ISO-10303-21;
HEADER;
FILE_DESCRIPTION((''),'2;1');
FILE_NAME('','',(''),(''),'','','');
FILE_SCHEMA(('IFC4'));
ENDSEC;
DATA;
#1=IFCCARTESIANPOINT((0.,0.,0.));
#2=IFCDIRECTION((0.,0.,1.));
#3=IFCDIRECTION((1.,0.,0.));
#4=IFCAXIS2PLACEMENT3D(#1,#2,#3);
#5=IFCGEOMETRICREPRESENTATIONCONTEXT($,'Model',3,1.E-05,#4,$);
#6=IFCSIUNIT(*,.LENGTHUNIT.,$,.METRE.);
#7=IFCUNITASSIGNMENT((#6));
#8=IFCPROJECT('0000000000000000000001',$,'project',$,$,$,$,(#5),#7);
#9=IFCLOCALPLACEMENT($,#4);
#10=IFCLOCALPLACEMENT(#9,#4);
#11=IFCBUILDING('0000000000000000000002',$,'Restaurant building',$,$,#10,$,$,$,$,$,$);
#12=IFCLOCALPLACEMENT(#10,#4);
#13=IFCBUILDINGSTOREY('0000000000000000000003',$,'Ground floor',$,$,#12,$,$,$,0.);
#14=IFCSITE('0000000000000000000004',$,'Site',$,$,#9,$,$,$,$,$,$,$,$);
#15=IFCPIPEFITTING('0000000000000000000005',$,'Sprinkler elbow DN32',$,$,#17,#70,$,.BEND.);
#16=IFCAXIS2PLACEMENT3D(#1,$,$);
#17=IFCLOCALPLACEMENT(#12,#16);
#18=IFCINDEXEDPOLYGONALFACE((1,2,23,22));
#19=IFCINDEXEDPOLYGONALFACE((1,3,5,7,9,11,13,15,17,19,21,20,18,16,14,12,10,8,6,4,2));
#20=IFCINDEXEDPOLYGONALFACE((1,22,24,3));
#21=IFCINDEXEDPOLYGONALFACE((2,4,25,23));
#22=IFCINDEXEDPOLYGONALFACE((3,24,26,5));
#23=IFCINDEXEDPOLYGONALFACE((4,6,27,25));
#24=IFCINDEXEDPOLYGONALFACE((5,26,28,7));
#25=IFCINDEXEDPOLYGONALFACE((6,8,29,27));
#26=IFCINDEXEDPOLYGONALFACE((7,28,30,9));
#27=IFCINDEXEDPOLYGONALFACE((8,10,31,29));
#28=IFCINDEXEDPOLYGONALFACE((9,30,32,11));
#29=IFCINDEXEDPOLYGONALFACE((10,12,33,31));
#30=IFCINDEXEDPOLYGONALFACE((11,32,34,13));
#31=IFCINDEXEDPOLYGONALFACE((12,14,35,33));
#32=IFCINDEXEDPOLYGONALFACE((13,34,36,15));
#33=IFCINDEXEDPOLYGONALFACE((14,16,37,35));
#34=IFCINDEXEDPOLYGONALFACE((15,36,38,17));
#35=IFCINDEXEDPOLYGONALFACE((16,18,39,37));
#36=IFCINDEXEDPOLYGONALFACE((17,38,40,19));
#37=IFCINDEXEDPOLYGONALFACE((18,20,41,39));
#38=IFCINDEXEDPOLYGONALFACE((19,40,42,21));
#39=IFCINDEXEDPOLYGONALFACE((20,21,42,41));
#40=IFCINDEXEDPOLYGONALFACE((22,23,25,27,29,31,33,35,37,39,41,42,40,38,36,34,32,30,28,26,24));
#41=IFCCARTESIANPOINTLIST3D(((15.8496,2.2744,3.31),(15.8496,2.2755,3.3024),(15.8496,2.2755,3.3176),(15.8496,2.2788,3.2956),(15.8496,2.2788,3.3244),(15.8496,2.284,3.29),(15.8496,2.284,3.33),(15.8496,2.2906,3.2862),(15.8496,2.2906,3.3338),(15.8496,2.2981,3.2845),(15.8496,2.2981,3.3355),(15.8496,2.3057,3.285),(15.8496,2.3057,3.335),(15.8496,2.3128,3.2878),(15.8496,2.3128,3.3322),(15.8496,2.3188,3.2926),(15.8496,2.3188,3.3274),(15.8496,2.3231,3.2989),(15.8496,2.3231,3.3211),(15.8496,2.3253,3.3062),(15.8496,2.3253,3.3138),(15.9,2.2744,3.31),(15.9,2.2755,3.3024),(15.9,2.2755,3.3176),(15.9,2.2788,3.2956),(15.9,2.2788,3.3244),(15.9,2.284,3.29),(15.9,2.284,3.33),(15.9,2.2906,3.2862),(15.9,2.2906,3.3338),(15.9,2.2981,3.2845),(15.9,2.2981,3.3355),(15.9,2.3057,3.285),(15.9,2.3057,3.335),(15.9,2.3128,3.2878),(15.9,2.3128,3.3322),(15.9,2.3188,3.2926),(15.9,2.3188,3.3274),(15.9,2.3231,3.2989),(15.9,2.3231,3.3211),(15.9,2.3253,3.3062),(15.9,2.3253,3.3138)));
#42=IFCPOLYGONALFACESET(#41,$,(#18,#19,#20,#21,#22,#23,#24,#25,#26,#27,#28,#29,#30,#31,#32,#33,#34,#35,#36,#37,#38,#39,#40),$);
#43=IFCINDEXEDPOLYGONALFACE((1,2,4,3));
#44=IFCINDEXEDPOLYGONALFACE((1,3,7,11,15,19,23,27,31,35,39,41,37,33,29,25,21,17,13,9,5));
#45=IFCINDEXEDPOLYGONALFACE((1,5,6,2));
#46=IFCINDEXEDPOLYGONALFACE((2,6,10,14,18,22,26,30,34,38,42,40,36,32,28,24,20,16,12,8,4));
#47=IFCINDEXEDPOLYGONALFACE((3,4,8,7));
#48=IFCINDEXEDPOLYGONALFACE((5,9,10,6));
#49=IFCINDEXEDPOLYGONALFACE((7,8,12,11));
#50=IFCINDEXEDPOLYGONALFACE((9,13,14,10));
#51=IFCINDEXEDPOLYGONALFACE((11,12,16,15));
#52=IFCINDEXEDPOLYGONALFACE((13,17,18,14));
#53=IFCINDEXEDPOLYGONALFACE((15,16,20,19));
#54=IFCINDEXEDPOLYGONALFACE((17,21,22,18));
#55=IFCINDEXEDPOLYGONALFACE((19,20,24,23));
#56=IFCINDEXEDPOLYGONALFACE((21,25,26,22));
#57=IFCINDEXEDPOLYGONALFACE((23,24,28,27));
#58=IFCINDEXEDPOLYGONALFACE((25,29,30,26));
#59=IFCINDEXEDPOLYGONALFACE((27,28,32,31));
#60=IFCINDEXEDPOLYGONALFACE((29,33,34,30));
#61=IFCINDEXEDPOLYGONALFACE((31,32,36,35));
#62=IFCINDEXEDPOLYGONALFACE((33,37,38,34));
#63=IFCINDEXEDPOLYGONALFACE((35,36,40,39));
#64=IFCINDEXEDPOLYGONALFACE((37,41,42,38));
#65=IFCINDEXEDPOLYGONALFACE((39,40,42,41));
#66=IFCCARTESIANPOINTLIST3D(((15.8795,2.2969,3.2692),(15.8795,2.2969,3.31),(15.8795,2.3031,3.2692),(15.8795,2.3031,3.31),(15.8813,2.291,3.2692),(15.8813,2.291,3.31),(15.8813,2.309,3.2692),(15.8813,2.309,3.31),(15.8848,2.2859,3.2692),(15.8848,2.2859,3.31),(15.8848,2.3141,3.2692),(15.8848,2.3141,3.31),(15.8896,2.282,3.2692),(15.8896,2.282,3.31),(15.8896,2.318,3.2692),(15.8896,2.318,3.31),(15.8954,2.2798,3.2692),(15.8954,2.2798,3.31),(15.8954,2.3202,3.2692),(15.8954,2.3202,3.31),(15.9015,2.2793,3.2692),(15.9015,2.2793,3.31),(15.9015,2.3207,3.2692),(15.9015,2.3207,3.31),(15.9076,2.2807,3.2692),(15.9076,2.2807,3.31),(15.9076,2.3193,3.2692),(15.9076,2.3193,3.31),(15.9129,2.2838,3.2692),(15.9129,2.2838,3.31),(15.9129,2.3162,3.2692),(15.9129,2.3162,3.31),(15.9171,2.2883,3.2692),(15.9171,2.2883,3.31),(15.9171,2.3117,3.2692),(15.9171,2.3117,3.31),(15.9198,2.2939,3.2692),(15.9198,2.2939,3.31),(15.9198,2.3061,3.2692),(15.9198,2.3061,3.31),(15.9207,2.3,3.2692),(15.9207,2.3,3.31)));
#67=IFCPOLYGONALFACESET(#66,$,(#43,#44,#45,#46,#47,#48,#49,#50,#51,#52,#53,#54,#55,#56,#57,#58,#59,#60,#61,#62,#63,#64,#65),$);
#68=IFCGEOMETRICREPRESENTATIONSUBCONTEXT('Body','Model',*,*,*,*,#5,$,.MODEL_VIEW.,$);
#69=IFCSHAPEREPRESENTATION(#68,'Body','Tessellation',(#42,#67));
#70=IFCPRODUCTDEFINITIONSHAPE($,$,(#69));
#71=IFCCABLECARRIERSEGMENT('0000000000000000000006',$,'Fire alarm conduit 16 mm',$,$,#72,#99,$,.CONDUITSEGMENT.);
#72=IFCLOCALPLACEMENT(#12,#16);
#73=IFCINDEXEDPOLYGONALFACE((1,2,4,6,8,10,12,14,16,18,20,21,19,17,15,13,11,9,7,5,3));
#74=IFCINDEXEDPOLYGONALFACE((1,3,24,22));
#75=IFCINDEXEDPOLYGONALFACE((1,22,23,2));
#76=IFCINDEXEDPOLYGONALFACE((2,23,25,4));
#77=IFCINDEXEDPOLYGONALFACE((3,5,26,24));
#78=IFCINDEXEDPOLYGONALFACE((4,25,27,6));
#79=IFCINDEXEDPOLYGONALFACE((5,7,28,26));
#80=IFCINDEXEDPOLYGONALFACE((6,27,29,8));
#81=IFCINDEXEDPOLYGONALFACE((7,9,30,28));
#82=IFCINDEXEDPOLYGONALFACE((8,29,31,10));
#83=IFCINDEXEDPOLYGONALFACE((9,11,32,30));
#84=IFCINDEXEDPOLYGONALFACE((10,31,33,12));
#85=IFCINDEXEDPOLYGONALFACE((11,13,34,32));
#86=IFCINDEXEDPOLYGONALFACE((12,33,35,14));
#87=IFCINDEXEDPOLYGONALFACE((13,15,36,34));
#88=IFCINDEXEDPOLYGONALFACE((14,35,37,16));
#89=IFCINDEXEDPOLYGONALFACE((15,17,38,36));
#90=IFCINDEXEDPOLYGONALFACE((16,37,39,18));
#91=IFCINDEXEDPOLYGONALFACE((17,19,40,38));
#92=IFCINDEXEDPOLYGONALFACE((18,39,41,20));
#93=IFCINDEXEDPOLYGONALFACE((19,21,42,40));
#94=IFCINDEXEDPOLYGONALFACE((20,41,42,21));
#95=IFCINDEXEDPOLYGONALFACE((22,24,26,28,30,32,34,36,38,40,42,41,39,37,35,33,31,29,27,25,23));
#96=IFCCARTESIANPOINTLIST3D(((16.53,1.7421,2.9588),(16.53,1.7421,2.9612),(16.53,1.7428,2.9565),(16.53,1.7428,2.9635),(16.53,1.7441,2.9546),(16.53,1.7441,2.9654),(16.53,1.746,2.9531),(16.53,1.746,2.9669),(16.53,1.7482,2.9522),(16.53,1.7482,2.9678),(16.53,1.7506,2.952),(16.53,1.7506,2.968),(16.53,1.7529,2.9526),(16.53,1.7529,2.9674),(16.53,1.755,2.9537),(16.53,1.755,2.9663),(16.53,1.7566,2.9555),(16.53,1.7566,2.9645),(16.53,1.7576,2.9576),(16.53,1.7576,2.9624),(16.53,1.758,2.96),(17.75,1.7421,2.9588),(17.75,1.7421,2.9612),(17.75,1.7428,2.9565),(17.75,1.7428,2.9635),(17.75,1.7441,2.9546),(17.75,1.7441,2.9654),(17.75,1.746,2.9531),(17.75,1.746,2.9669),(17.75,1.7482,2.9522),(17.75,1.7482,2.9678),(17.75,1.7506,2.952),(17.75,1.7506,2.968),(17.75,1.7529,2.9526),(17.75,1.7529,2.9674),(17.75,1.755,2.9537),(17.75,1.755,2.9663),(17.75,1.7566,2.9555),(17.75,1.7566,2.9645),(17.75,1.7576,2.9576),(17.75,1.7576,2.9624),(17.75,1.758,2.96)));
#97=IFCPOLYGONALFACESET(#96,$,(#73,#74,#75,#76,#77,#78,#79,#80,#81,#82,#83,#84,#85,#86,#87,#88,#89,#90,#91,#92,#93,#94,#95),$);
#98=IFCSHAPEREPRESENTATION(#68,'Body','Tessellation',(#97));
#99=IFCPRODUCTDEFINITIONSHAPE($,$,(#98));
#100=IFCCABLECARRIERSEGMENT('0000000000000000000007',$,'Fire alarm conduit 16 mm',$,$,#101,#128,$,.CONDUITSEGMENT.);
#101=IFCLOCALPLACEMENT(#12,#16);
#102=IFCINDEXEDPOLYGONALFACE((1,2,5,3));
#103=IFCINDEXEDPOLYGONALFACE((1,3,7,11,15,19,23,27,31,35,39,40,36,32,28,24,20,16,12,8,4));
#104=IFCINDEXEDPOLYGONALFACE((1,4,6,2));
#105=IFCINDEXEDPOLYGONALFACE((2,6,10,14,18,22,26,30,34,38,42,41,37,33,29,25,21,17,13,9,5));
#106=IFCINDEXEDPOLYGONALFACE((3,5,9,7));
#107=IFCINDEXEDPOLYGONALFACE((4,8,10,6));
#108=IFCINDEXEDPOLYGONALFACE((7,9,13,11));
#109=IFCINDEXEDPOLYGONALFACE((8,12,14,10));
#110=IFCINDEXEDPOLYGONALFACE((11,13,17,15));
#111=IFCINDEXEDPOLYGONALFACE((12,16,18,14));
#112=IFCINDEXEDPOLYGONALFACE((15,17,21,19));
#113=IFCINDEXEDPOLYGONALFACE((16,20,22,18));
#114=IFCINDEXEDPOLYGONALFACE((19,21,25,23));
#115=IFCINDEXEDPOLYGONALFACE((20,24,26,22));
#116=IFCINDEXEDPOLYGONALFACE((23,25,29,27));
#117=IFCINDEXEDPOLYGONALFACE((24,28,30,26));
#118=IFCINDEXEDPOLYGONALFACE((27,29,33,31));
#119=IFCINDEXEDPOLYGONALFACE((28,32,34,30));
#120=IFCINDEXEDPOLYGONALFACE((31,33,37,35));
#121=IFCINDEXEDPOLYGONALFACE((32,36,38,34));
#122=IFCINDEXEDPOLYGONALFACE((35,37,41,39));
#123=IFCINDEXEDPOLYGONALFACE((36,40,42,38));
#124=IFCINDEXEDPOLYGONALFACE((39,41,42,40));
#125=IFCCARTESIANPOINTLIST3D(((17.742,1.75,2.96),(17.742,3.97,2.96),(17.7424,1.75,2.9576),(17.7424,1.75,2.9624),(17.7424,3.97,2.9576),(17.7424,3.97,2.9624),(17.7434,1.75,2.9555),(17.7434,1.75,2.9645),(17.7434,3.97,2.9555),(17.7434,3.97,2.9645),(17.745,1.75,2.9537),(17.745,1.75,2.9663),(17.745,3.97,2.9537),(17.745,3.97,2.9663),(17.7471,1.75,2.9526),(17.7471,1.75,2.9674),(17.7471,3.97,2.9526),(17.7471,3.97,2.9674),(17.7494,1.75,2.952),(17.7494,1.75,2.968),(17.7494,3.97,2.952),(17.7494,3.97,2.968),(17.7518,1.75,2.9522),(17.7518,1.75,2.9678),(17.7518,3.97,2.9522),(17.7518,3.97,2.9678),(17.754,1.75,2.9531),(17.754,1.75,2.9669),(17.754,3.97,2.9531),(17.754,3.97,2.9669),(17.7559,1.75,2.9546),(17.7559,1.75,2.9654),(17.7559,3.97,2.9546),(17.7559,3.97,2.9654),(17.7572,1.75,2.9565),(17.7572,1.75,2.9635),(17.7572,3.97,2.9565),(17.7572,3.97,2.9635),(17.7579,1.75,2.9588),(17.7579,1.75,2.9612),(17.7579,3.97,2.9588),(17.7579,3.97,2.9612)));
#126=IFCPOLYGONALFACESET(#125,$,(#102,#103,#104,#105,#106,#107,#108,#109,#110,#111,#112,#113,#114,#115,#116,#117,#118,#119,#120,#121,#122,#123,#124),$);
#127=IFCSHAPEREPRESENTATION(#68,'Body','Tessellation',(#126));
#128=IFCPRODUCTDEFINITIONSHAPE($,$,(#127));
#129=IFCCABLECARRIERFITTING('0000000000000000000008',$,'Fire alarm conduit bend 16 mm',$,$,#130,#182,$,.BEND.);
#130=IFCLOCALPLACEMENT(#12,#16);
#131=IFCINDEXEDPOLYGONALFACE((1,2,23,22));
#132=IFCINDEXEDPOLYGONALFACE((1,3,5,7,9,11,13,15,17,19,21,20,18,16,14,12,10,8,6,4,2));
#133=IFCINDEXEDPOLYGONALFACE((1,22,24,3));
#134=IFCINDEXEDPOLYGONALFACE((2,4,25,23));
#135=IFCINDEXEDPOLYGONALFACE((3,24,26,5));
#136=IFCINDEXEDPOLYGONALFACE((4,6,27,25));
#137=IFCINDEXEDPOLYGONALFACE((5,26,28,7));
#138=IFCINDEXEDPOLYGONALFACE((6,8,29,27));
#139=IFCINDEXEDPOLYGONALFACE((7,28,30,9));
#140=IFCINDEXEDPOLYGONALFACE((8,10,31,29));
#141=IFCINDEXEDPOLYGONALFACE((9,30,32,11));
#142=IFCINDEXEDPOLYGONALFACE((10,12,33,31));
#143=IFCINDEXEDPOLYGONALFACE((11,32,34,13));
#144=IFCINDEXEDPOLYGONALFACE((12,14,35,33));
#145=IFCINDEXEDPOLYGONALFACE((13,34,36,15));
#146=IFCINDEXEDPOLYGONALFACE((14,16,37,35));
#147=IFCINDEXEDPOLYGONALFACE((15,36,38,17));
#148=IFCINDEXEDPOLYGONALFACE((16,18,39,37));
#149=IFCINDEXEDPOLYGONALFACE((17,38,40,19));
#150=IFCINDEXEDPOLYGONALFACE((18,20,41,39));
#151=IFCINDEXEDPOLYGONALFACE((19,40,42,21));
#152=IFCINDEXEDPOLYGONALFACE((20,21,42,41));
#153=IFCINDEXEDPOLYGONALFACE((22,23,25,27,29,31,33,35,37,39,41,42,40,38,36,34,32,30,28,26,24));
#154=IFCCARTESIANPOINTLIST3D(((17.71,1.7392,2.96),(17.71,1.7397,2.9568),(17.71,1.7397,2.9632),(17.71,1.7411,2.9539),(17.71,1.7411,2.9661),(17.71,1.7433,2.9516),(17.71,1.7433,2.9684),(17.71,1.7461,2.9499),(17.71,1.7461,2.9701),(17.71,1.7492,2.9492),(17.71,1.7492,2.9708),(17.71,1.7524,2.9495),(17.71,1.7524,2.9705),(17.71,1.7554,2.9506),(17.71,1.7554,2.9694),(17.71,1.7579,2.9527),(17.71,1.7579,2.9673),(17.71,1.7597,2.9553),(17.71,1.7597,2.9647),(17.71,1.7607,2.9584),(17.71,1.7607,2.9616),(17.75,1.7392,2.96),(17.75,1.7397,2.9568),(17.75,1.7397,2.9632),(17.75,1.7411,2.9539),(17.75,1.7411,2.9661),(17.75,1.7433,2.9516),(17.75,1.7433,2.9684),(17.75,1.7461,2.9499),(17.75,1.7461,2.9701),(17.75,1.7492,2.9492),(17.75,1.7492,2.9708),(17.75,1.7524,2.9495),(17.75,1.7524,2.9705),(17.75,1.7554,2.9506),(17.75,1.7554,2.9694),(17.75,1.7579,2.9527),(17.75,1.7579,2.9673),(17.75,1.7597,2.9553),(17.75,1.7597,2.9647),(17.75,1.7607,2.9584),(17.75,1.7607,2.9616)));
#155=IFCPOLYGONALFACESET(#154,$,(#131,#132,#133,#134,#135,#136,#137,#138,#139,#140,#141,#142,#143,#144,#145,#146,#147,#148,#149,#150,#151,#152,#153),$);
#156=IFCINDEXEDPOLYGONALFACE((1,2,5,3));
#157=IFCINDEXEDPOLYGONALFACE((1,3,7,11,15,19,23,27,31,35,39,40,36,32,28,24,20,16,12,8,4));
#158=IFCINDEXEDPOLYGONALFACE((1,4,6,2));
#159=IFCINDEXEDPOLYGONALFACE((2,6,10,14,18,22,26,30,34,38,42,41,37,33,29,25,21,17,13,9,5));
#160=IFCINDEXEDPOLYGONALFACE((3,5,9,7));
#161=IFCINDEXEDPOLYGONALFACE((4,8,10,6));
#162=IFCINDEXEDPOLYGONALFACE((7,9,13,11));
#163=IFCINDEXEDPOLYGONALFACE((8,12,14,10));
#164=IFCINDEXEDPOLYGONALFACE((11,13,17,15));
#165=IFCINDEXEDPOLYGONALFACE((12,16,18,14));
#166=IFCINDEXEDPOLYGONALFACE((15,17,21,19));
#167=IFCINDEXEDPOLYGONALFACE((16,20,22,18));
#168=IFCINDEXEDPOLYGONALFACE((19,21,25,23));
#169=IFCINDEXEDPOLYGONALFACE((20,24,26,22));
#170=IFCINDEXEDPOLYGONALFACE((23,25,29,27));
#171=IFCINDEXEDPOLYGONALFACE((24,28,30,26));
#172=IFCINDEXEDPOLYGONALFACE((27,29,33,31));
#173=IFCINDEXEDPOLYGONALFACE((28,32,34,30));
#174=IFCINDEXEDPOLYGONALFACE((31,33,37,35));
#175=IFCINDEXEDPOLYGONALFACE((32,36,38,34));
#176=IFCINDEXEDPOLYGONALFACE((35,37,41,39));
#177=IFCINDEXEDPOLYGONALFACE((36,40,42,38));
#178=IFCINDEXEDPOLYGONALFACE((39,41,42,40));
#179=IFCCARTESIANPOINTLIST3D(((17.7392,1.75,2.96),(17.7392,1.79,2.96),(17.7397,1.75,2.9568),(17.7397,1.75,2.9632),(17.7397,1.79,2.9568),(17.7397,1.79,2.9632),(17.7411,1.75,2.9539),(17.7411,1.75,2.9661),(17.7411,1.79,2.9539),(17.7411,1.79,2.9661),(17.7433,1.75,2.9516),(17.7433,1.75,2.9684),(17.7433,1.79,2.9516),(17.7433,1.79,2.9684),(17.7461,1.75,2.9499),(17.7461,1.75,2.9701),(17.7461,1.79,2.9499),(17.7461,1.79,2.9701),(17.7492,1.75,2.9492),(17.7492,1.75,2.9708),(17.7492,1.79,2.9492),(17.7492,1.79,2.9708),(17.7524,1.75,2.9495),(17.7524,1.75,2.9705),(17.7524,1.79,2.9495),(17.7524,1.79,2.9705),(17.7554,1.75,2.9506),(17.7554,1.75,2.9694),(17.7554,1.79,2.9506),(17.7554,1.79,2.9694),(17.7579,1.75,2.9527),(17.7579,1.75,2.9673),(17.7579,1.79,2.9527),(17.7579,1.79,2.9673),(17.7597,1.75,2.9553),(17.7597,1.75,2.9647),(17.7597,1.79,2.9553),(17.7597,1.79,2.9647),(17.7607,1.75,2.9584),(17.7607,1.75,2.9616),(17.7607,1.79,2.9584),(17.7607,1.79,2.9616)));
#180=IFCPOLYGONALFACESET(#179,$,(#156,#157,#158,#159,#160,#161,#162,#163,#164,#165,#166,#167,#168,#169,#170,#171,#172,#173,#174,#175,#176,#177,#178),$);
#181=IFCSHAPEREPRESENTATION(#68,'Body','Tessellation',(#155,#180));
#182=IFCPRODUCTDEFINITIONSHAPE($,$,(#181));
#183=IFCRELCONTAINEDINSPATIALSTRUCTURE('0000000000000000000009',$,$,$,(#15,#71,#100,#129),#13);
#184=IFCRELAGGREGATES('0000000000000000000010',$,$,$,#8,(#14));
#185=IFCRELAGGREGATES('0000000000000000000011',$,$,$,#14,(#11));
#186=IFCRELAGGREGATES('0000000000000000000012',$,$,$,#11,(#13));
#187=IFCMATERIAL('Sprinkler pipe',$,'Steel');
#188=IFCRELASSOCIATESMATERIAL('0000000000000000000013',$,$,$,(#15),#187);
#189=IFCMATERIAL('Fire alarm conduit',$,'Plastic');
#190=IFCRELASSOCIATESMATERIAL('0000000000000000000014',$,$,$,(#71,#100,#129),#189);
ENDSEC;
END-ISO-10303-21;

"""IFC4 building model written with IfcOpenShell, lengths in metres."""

from ifc_helpers import new_model, si_unit, frame, origin_with_axes, origin_2d, place, context, subcontext, project, spatial, circle, extrude, material, element, save


model = new_model("IFC4")

# Units and contexts
model_context = context("Model", 3, precision=1e-05, world=origin_with_axes())
body_context = subcontext(model_context, "Body", "Model", "MODEL_VIEW")
ifc_project = project(units=[si_unit("LENGTHUNIT", "METRE")], contexts=[model_context])

# Site, building, storey
site_placement = place(None, origin_with_axes())
site = spatial("IfcSite", under=ifc_project, at=site_placement, Name="Site")
building_placement = place(site_placement, origin_with_axes())
building = spatial("IfcBuilding", under=site, at=building_placement, Name="Restaurant building")
storey_placement = place(building_placement, origin_with_axes())
storey = spatial("IfcBuildingStorey", under=building, at=storey_placement, Name="Ground floor", Elevation=0.0)

# Shared definitions
ifc_material_1 = material(Name="Sprinkler pipe", Category="Steel")

# Pipe fitting
pipe_fitting_placement = place(storey_placement, frame((15.9, 2.3, 3.31)))
element("IfcPipeFitting", 1, at=pipe_fitting_placement, inside=storey, material=ifc_material_1, Name="Sprinkler elbow DN32", PredefinedType="BEND", context=body_context, shape_type="SweptSolid", body=[
    extrude(circle(Radius=0.0256, at=origin_2d()), frame((0.0, 0.0, 0.0), z_axis=(-1.0, 0.0, 0.0), x_axis=(0.0, -1.0, 0.0)), (0.0, 0.0, 1.0), 0.0504),
    extrude(circle(Radius=0.0207, at=origin_2d()), frame((0.0, 0.0, 0.0), z_axis=(0.0, 0.0, -1.0), x_axis=(1.0, 0.0, 0.0)), (0.0, 0.0, 1.0), 0.0408),
])

# Cable carrier segments
ifc_material_2 = material(Name="Fire alarm conduit", Category="Plastic")
cable_carrier_segment_1_placement = place(storey_placement, frame((16.53, 1.75, 2.96)))
element("IfcCableCarrierSegment", 2, at=cable_carrier_segment_1_placement, inside=storey, material=ifc_material_2, Name="Fire alarm conduit 16 mm", PredefinedType="CONDUITSEGMENT", context=body_context, shape_type="SweptSolid", body=[
    extrude(circle(Radius=0.008, at=origin_2d()), frame((0.0, 0.0, 0.0), z_axis=(1.0, 0.0, 0.0), x_axis=(0.0, 1.0, 0.0)), (0.0, 0.0, 1.0), 1.22),
])
cable_carrier_segment_2_placement = place(storey_placement, frame((17.75, 1.75, 2.96)))
element("IfcCableCarrierSegment", 3, at=cable_carrier_segment_2_placement, inside=storey, material=ifc_material_2, Name="Fire alarm conduit 16 mm", PredefinedType="CONDUITSEGMENT", context=body_context, shape_type="SweptSolid", body=[
    extrude(circle(Radius=0.008, at=origin_2d()), frame((0.0, 0.0, 0.0), z_axis=(0.0, 1.0, 0.0), x_axis=(-1.0, 0.0, 0.0)), (0.0, 0.0, 1.0), 2.22),
])

# Cable carrier fitting
cable_carrier_fitting_1_placement = place(storey_placement, frame((17.75, 1.75, 2.96)))
element("IfcCableCarrierFitting", 4, at=cable_carrier_fitting_1_placement, inside=storey, material=ifc_material_2, Name="Fire alarm conduit bend 16 mm", PredefinedType="BEND", context=body_context, shape_type="SweptSolid", body=[
    extrude(circle(Radius=0.0108, at=origin_2d()), frame((0.0, 0.0, 0.0), z_axis=(-1.0, 0.0, 0.0), x_axis=(0.0, -1.0, 0.0)), (0.0, 0.0, 1.0), 0.04),
    extrude(circle(Radius=0.0108, at=origin_2d()), frame((0.0, 0.0, 0.0), z_axis=(0.0, 1.0, 0.0), x_axis=(-1.0, 0.0, 0.0)), (0.0, 0.0, 1.0), 0.04),
])

save(model, "model.ifc")
